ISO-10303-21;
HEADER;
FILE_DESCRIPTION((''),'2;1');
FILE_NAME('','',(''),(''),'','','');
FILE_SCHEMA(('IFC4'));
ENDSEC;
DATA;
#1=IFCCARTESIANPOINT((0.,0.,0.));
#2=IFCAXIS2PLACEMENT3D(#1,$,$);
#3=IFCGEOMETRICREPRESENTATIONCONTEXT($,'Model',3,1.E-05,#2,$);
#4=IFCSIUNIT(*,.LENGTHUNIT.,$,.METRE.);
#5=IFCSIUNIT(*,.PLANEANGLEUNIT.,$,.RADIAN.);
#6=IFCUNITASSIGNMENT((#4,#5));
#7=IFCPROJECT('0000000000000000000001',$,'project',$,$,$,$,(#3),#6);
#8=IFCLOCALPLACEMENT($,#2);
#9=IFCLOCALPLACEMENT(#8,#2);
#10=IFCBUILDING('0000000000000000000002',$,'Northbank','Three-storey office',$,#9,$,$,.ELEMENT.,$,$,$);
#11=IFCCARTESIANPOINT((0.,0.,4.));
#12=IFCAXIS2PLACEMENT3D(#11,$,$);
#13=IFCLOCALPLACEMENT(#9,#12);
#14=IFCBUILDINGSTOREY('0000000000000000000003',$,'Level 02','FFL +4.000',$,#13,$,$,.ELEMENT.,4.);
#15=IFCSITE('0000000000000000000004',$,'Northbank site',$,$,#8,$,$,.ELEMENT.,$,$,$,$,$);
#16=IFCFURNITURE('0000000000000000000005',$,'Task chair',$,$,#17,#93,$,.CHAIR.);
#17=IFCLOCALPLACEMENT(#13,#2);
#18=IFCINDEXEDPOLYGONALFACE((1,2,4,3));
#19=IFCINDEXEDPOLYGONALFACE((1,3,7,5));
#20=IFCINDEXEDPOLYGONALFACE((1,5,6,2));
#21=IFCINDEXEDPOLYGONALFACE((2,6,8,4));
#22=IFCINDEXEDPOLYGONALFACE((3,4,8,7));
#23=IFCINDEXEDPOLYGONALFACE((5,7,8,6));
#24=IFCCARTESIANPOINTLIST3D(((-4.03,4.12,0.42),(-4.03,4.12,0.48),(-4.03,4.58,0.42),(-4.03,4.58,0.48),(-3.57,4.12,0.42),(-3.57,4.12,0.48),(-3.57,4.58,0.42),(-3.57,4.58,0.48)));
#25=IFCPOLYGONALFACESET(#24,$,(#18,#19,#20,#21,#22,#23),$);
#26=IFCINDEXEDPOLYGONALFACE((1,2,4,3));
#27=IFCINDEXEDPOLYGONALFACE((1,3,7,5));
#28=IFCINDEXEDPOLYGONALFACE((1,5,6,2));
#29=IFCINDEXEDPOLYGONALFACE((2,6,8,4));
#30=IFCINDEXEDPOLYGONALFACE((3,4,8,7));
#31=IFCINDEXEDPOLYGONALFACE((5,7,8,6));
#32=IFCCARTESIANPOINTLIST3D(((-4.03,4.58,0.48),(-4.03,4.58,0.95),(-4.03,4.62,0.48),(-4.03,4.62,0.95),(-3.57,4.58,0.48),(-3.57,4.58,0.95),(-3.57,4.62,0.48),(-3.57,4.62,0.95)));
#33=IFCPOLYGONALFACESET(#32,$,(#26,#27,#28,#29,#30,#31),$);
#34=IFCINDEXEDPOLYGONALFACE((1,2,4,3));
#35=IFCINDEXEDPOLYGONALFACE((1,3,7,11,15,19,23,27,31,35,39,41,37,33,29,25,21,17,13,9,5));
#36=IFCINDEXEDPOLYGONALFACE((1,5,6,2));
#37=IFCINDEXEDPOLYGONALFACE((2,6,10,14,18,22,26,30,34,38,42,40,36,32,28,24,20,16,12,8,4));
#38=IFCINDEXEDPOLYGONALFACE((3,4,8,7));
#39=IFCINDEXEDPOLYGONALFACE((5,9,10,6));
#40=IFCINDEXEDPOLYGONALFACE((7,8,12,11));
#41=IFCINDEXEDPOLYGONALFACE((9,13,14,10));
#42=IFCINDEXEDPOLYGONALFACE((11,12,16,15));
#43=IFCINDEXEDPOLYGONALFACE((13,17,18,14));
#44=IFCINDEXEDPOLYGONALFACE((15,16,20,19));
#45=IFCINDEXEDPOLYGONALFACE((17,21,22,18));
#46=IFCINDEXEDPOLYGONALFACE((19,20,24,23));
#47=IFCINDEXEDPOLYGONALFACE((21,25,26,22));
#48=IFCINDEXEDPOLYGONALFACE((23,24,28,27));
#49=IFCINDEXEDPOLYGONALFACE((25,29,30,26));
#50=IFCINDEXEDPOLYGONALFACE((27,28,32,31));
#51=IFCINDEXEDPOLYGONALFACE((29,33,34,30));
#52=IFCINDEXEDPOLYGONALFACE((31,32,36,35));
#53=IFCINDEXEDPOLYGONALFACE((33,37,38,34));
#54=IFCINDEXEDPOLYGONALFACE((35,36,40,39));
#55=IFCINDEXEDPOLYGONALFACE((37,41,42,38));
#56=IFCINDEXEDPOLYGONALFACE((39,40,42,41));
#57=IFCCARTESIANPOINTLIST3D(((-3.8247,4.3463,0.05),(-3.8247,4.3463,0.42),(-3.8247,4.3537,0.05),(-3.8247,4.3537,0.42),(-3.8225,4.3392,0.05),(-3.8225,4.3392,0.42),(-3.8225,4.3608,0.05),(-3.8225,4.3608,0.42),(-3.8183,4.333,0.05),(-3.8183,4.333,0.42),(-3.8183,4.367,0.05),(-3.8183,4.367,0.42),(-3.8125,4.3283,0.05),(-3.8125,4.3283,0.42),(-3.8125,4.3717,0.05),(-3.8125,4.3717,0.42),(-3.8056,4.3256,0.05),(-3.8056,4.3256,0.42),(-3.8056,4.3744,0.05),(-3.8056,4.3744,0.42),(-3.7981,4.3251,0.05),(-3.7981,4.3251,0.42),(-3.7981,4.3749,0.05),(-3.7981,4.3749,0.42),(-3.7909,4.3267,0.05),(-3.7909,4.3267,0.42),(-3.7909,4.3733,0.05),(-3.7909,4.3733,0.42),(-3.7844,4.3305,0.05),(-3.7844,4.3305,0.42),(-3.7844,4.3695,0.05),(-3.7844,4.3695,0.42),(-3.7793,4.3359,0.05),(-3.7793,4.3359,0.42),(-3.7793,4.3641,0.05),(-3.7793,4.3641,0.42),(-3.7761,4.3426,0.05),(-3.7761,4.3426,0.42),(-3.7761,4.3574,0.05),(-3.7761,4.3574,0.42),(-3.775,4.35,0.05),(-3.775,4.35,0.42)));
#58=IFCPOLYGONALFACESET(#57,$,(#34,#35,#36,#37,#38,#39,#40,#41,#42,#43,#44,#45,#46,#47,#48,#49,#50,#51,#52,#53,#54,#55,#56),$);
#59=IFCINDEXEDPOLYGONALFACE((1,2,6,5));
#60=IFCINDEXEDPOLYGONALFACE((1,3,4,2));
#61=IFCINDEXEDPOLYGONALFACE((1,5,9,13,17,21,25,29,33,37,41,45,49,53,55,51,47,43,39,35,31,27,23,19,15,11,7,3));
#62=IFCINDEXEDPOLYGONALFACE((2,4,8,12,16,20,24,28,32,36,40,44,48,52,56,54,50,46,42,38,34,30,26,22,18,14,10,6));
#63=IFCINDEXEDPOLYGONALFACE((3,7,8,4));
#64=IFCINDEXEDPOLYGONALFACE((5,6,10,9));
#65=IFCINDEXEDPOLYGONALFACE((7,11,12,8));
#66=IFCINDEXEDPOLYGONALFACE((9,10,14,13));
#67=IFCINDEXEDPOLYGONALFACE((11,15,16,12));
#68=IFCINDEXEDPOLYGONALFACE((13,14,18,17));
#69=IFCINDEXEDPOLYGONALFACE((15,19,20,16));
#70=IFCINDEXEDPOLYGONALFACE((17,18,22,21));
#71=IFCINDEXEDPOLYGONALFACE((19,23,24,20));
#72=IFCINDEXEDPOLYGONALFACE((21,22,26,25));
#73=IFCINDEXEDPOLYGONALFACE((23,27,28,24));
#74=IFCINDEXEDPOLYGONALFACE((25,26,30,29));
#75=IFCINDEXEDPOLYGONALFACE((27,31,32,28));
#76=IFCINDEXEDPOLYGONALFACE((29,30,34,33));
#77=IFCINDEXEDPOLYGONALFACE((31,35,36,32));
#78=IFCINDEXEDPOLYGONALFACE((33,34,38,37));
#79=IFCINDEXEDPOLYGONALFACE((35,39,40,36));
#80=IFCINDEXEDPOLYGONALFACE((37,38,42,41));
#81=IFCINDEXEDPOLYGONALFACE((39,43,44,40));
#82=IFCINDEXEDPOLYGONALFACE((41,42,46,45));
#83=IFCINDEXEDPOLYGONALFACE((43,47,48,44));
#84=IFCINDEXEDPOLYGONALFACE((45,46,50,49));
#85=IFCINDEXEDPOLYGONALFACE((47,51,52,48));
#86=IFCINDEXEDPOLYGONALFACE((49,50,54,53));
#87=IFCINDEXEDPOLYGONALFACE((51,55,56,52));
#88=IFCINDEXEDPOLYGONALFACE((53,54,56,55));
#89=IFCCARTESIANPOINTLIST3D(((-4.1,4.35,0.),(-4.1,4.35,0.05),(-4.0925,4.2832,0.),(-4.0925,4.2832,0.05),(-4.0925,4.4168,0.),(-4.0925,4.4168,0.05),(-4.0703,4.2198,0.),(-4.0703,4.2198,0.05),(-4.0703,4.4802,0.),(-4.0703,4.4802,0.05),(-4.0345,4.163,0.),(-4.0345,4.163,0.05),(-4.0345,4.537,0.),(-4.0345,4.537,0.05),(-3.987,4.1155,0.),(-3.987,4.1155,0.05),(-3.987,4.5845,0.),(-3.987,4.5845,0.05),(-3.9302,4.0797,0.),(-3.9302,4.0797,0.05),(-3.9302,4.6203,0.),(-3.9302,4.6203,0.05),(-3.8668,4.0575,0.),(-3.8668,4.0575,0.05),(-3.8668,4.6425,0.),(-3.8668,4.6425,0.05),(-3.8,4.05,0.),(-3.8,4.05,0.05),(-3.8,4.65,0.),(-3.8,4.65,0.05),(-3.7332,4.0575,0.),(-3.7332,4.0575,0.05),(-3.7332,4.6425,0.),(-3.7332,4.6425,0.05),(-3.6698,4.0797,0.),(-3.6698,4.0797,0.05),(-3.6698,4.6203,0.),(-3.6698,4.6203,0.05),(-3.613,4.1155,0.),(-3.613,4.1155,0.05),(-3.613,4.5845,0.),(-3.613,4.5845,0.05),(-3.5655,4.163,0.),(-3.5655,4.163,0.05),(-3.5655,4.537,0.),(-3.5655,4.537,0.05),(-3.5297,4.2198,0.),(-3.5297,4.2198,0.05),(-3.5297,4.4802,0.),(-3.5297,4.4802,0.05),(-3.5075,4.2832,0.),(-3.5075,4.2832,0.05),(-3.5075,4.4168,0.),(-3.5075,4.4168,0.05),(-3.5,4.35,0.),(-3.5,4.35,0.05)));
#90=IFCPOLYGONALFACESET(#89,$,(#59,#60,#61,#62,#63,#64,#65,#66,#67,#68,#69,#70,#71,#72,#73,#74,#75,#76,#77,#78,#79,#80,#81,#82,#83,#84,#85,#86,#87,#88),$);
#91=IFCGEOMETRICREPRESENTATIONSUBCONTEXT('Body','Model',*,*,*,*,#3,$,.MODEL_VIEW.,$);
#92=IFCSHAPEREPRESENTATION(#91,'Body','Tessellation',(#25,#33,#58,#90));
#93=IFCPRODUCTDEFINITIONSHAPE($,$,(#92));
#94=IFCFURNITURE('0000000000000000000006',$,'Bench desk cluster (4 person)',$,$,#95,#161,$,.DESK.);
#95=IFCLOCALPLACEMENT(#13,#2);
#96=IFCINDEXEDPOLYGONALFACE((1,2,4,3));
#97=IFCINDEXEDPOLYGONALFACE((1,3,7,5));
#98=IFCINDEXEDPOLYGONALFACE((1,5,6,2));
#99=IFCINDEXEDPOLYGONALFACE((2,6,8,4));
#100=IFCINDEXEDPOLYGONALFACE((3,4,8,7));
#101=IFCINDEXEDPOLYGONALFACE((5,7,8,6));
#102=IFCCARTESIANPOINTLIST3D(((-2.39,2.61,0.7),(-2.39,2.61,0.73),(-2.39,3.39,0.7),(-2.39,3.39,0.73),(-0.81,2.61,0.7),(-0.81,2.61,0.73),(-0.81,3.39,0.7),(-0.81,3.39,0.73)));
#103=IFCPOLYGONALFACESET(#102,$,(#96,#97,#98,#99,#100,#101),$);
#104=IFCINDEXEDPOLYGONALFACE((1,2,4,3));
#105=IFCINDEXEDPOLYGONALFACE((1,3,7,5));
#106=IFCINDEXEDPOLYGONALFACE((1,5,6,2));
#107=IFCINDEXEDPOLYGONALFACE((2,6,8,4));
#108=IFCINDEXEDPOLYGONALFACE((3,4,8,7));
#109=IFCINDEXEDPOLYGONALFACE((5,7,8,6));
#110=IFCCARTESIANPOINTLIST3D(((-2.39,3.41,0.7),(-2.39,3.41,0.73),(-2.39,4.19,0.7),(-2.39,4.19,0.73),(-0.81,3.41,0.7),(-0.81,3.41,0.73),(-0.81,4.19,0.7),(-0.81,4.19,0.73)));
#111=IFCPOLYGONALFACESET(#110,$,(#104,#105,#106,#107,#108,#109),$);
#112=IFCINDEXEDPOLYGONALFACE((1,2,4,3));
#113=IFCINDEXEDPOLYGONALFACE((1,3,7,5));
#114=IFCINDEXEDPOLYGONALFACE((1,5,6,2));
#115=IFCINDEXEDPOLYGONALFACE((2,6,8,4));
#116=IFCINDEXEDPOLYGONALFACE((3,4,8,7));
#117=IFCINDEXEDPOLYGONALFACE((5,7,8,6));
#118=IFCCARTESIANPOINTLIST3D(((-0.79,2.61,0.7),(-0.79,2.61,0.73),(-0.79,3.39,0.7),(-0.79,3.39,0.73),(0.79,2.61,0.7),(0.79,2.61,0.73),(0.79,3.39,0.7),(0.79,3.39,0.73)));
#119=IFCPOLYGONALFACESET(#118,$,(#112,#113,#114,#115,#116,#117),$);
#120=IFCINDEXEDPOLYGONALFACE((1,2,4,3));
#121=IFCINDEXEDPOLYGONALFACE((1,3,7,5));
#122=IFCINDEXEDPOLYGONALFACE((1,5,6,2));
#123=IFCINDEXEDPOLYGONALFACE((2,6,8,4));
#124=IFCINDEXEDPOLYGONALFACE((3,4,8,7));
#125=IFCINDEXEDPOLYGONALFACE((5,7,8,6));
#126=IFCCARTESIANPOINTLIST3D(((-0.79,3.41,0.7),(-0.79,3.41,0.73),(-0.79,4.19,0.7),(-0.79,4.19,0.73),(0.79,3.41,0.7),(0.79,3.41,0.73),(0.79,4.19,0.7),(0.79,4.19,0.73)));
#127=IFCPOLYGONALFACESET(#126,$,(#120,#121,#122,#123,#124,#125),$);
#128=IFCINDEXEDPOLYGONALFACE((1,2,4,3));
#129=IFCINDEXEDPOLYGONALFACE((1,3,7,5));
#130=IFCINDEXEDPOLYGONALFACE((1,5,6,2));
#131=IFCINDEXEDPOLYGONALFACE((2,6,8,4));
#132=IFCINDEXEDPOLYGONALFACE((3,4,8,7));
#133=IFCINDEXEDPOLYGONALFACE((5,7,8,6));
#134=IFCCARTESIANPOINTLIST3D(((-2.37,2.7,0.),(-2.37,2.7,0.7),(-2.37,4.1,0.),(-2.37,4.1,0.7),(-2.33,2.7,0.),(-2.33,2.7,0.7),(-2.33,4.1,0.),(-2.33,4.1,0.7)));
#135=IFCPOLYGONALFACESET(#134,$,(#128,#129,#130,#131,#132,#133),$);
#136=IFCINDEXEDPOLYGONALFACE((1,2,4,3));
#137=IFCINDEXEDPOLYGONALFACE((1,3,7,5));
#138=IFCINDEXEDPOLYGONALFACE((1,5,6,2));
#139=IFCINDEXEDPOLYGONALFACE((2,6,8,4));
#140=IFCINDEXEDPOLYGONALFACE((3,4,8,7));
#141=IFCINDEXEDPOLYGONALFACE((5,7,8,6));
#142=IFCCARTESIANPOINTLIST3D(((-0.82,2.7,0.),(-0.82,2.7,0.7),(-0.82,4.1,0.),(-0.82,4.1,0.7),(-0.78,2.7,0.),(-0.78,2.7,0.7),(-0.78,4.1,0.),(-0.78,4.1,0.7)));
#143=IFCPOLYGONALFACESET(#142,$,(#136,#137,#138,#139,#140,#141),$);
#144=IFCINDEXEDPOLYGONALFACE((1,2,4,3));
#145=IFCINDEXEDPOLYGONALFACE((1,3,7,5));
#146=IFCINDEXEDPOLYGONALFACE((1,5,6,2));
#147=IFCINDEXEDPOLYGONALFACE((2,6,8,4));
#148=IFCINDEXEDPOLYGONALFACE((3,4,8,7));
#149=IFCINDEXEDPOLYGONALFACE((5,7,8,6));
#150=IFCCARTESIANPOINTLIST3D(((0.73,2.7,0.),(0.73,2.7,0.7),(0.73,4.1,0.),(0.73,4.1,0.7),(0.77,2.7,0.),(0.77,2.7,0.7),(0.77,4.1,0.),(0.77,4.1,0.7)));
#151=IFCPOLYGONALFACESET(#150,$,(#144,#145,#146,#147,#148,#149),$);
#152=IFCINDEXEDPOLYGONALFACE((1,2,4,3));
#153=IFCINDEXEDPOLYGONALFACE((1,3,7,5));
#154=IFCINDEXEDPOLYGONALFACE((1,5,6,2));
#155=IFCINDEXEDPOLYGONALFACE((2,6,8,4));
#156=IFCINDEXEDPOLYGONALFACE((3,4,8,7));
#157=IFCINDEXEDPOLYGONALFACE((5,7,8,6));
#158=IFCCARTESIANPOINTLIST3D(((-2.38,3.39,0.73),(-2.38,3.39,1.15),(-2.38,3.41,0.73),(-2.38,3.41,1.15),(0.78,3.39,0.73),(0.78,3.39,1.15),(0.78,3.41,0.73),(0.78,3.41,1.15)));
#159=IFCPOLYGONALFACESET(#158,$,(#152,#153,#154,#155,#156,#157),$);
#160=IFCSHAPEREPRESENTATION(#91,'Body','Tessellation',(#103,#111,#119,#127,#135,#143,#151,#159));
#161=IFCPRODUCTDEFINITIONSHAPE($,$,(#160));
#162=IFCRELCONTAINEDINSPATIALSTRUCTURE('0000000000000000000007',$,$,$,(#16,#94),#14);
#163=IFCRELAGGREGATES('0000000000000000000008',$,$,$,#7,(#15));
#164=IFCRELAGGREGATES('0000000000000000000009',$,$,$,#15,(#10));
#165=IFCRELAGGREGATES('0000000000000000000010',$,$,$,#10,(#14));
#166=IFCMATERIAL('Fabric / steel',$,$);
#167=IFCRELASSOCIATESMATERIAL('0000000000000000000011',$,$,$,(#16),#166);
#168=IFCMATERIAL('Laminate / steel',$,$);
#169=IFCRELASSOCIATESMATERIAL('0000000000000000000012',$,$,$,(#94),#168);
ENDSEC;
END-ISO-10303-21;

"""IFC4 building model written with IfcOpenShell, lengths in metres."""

from ifc_helpers import new_model, si_unit, frame, origin, place, context, subcontext, project, spatial, rectangle, circle, extrude, material, element, save


model = new_model("IFC4")

# Units and contexts
model_context = context("Model", 3, precision=1e-05, world=origin())
body_context = subcontext(model_context, "Body", "Model", "MODEL_VIEW")
ifc_project = project(units=[si_unit("LENGTHUNIT", "METRE"), si_unit("PLANEANGLEUNIT", "RADIAN")], contexts=[model_context])

# Site, building, storey
site_placement = place(None, origin())
site = spatial("IfcSite", under=ifc_project, at=site_placement, Name="Northbank site", CompositionType="ELEMENT")
building_placement = place(site_placement, origin())
building = spatial("IfcBuilding", under=site, at=building_placement, Name="Northbank", Description="Three-storey office", CompositionType="ELEMENT")
storey_placement = place(building_placement, frame((0.0, 0.0, 4.0)))
storey = spatial("IfcBuildingStorey", under=building, at=storey_placement, Name="Level 02", Description="FFL +4.000", CompositionType="ELEMENT", Elevation=4.0)

# Furniture
ifc_material_1 = material(Name="Laminate / steel")
ifc_material_2 = material(Name="Fabric / steel")
furniture_1_placement = place(storey_placement, frame((0.0, 0.0, -4.0)))
element("IfcFurniture", 1, at=furniture_1_placement, inside=storey, material=ifc_material_2, Name="Task chair", PredefinedType="CHAIR", context=body_context, shape_type="SweptSolid", body=[
    extrude(rectangle(XDim=0.46, YDim=0.46), frame((-3.8, 4.35, 4.42)), (0.0, 0.0, 1.0), 0.06),
    extrude(rectangle(XDim=0.46, YDim=0.04), frame((-3.8, 4.6, 4.48)), (0.0, 0.0, 1.0), 0.47),
    extrude(circle(Radius=0.025), frame((-3.8, 4.35, 4.05), z_axis=(0.0, 0.0, 1.0), x_axis=(1.0, 0.0, 0.0)), (0.0, 0.0, 1.0), 0.37),
    extrude(circle(Radius=0.3), frame((-3.8, 4.35, 4.0), z_axis=(0.0, 0.0, 1.0), x_axis=(1.0, 0.0, 0.0)), (0.0, 0.0, 1.0), 0.05),
])
furniture_2_placement = place(storey_placement, frame((0.0, 0.0, -4.0)))
element("IfcFurniture", 2, at=furniture_2_placement, inside=storey, material=ifc_material_1, Name="Bench desk cluster (4 person)", PredefinedType="DESK", context=body_context, shape_type="SweptSolid", body=[
    extrude(rectangle(XDim=1.58, YDim=0.78), frame((-1.6, 3.0, 4.7)), (0.0, 0.0, 1.0), 0.03),
    extrude(rectangle(XDim=1.58, YDim=0.78), frame((-1.6, 3.8, 4.7)), (0.0, 0.0, 1.0), 0.03),
    extrude(rectangle(XDim=1.58, YDim=0.78), frame((0.0, 3.0, 4.7)), (0.0, 0.0, 1.0), 0.03),
    extrude(rectangle(XDim=1.58, YDim=0.78), frame((0.0, 3.8, 4.7)), (0.0, 0.0, 1.0), 0.03),
    extrude(rectangle(XDim=0.04, YDim=1.4), frame((-2.35, 3.4, 4.0)), (0.0, 0.0, 1.0), 0.7),
    extrude(rectangle(XDim=0.04, YDim=1.4), frame((-0.8, 3.4, 4.0)), (0.0, 0.0, 1.0), 0.7),
    extrude(rectangle(XDim=0.04, YDim=1.4), frame((0.75, 3.4, 4.0)), (0.0, 0.0, 1.0), 0.7),
    extrude(rectangle(XDim=3.16, YDim=0.02), frame((-0.8, 3.4, 4.73)), (0.0, 0.0, 1.0), 0.42),
])

save(model, "model.ifc")
